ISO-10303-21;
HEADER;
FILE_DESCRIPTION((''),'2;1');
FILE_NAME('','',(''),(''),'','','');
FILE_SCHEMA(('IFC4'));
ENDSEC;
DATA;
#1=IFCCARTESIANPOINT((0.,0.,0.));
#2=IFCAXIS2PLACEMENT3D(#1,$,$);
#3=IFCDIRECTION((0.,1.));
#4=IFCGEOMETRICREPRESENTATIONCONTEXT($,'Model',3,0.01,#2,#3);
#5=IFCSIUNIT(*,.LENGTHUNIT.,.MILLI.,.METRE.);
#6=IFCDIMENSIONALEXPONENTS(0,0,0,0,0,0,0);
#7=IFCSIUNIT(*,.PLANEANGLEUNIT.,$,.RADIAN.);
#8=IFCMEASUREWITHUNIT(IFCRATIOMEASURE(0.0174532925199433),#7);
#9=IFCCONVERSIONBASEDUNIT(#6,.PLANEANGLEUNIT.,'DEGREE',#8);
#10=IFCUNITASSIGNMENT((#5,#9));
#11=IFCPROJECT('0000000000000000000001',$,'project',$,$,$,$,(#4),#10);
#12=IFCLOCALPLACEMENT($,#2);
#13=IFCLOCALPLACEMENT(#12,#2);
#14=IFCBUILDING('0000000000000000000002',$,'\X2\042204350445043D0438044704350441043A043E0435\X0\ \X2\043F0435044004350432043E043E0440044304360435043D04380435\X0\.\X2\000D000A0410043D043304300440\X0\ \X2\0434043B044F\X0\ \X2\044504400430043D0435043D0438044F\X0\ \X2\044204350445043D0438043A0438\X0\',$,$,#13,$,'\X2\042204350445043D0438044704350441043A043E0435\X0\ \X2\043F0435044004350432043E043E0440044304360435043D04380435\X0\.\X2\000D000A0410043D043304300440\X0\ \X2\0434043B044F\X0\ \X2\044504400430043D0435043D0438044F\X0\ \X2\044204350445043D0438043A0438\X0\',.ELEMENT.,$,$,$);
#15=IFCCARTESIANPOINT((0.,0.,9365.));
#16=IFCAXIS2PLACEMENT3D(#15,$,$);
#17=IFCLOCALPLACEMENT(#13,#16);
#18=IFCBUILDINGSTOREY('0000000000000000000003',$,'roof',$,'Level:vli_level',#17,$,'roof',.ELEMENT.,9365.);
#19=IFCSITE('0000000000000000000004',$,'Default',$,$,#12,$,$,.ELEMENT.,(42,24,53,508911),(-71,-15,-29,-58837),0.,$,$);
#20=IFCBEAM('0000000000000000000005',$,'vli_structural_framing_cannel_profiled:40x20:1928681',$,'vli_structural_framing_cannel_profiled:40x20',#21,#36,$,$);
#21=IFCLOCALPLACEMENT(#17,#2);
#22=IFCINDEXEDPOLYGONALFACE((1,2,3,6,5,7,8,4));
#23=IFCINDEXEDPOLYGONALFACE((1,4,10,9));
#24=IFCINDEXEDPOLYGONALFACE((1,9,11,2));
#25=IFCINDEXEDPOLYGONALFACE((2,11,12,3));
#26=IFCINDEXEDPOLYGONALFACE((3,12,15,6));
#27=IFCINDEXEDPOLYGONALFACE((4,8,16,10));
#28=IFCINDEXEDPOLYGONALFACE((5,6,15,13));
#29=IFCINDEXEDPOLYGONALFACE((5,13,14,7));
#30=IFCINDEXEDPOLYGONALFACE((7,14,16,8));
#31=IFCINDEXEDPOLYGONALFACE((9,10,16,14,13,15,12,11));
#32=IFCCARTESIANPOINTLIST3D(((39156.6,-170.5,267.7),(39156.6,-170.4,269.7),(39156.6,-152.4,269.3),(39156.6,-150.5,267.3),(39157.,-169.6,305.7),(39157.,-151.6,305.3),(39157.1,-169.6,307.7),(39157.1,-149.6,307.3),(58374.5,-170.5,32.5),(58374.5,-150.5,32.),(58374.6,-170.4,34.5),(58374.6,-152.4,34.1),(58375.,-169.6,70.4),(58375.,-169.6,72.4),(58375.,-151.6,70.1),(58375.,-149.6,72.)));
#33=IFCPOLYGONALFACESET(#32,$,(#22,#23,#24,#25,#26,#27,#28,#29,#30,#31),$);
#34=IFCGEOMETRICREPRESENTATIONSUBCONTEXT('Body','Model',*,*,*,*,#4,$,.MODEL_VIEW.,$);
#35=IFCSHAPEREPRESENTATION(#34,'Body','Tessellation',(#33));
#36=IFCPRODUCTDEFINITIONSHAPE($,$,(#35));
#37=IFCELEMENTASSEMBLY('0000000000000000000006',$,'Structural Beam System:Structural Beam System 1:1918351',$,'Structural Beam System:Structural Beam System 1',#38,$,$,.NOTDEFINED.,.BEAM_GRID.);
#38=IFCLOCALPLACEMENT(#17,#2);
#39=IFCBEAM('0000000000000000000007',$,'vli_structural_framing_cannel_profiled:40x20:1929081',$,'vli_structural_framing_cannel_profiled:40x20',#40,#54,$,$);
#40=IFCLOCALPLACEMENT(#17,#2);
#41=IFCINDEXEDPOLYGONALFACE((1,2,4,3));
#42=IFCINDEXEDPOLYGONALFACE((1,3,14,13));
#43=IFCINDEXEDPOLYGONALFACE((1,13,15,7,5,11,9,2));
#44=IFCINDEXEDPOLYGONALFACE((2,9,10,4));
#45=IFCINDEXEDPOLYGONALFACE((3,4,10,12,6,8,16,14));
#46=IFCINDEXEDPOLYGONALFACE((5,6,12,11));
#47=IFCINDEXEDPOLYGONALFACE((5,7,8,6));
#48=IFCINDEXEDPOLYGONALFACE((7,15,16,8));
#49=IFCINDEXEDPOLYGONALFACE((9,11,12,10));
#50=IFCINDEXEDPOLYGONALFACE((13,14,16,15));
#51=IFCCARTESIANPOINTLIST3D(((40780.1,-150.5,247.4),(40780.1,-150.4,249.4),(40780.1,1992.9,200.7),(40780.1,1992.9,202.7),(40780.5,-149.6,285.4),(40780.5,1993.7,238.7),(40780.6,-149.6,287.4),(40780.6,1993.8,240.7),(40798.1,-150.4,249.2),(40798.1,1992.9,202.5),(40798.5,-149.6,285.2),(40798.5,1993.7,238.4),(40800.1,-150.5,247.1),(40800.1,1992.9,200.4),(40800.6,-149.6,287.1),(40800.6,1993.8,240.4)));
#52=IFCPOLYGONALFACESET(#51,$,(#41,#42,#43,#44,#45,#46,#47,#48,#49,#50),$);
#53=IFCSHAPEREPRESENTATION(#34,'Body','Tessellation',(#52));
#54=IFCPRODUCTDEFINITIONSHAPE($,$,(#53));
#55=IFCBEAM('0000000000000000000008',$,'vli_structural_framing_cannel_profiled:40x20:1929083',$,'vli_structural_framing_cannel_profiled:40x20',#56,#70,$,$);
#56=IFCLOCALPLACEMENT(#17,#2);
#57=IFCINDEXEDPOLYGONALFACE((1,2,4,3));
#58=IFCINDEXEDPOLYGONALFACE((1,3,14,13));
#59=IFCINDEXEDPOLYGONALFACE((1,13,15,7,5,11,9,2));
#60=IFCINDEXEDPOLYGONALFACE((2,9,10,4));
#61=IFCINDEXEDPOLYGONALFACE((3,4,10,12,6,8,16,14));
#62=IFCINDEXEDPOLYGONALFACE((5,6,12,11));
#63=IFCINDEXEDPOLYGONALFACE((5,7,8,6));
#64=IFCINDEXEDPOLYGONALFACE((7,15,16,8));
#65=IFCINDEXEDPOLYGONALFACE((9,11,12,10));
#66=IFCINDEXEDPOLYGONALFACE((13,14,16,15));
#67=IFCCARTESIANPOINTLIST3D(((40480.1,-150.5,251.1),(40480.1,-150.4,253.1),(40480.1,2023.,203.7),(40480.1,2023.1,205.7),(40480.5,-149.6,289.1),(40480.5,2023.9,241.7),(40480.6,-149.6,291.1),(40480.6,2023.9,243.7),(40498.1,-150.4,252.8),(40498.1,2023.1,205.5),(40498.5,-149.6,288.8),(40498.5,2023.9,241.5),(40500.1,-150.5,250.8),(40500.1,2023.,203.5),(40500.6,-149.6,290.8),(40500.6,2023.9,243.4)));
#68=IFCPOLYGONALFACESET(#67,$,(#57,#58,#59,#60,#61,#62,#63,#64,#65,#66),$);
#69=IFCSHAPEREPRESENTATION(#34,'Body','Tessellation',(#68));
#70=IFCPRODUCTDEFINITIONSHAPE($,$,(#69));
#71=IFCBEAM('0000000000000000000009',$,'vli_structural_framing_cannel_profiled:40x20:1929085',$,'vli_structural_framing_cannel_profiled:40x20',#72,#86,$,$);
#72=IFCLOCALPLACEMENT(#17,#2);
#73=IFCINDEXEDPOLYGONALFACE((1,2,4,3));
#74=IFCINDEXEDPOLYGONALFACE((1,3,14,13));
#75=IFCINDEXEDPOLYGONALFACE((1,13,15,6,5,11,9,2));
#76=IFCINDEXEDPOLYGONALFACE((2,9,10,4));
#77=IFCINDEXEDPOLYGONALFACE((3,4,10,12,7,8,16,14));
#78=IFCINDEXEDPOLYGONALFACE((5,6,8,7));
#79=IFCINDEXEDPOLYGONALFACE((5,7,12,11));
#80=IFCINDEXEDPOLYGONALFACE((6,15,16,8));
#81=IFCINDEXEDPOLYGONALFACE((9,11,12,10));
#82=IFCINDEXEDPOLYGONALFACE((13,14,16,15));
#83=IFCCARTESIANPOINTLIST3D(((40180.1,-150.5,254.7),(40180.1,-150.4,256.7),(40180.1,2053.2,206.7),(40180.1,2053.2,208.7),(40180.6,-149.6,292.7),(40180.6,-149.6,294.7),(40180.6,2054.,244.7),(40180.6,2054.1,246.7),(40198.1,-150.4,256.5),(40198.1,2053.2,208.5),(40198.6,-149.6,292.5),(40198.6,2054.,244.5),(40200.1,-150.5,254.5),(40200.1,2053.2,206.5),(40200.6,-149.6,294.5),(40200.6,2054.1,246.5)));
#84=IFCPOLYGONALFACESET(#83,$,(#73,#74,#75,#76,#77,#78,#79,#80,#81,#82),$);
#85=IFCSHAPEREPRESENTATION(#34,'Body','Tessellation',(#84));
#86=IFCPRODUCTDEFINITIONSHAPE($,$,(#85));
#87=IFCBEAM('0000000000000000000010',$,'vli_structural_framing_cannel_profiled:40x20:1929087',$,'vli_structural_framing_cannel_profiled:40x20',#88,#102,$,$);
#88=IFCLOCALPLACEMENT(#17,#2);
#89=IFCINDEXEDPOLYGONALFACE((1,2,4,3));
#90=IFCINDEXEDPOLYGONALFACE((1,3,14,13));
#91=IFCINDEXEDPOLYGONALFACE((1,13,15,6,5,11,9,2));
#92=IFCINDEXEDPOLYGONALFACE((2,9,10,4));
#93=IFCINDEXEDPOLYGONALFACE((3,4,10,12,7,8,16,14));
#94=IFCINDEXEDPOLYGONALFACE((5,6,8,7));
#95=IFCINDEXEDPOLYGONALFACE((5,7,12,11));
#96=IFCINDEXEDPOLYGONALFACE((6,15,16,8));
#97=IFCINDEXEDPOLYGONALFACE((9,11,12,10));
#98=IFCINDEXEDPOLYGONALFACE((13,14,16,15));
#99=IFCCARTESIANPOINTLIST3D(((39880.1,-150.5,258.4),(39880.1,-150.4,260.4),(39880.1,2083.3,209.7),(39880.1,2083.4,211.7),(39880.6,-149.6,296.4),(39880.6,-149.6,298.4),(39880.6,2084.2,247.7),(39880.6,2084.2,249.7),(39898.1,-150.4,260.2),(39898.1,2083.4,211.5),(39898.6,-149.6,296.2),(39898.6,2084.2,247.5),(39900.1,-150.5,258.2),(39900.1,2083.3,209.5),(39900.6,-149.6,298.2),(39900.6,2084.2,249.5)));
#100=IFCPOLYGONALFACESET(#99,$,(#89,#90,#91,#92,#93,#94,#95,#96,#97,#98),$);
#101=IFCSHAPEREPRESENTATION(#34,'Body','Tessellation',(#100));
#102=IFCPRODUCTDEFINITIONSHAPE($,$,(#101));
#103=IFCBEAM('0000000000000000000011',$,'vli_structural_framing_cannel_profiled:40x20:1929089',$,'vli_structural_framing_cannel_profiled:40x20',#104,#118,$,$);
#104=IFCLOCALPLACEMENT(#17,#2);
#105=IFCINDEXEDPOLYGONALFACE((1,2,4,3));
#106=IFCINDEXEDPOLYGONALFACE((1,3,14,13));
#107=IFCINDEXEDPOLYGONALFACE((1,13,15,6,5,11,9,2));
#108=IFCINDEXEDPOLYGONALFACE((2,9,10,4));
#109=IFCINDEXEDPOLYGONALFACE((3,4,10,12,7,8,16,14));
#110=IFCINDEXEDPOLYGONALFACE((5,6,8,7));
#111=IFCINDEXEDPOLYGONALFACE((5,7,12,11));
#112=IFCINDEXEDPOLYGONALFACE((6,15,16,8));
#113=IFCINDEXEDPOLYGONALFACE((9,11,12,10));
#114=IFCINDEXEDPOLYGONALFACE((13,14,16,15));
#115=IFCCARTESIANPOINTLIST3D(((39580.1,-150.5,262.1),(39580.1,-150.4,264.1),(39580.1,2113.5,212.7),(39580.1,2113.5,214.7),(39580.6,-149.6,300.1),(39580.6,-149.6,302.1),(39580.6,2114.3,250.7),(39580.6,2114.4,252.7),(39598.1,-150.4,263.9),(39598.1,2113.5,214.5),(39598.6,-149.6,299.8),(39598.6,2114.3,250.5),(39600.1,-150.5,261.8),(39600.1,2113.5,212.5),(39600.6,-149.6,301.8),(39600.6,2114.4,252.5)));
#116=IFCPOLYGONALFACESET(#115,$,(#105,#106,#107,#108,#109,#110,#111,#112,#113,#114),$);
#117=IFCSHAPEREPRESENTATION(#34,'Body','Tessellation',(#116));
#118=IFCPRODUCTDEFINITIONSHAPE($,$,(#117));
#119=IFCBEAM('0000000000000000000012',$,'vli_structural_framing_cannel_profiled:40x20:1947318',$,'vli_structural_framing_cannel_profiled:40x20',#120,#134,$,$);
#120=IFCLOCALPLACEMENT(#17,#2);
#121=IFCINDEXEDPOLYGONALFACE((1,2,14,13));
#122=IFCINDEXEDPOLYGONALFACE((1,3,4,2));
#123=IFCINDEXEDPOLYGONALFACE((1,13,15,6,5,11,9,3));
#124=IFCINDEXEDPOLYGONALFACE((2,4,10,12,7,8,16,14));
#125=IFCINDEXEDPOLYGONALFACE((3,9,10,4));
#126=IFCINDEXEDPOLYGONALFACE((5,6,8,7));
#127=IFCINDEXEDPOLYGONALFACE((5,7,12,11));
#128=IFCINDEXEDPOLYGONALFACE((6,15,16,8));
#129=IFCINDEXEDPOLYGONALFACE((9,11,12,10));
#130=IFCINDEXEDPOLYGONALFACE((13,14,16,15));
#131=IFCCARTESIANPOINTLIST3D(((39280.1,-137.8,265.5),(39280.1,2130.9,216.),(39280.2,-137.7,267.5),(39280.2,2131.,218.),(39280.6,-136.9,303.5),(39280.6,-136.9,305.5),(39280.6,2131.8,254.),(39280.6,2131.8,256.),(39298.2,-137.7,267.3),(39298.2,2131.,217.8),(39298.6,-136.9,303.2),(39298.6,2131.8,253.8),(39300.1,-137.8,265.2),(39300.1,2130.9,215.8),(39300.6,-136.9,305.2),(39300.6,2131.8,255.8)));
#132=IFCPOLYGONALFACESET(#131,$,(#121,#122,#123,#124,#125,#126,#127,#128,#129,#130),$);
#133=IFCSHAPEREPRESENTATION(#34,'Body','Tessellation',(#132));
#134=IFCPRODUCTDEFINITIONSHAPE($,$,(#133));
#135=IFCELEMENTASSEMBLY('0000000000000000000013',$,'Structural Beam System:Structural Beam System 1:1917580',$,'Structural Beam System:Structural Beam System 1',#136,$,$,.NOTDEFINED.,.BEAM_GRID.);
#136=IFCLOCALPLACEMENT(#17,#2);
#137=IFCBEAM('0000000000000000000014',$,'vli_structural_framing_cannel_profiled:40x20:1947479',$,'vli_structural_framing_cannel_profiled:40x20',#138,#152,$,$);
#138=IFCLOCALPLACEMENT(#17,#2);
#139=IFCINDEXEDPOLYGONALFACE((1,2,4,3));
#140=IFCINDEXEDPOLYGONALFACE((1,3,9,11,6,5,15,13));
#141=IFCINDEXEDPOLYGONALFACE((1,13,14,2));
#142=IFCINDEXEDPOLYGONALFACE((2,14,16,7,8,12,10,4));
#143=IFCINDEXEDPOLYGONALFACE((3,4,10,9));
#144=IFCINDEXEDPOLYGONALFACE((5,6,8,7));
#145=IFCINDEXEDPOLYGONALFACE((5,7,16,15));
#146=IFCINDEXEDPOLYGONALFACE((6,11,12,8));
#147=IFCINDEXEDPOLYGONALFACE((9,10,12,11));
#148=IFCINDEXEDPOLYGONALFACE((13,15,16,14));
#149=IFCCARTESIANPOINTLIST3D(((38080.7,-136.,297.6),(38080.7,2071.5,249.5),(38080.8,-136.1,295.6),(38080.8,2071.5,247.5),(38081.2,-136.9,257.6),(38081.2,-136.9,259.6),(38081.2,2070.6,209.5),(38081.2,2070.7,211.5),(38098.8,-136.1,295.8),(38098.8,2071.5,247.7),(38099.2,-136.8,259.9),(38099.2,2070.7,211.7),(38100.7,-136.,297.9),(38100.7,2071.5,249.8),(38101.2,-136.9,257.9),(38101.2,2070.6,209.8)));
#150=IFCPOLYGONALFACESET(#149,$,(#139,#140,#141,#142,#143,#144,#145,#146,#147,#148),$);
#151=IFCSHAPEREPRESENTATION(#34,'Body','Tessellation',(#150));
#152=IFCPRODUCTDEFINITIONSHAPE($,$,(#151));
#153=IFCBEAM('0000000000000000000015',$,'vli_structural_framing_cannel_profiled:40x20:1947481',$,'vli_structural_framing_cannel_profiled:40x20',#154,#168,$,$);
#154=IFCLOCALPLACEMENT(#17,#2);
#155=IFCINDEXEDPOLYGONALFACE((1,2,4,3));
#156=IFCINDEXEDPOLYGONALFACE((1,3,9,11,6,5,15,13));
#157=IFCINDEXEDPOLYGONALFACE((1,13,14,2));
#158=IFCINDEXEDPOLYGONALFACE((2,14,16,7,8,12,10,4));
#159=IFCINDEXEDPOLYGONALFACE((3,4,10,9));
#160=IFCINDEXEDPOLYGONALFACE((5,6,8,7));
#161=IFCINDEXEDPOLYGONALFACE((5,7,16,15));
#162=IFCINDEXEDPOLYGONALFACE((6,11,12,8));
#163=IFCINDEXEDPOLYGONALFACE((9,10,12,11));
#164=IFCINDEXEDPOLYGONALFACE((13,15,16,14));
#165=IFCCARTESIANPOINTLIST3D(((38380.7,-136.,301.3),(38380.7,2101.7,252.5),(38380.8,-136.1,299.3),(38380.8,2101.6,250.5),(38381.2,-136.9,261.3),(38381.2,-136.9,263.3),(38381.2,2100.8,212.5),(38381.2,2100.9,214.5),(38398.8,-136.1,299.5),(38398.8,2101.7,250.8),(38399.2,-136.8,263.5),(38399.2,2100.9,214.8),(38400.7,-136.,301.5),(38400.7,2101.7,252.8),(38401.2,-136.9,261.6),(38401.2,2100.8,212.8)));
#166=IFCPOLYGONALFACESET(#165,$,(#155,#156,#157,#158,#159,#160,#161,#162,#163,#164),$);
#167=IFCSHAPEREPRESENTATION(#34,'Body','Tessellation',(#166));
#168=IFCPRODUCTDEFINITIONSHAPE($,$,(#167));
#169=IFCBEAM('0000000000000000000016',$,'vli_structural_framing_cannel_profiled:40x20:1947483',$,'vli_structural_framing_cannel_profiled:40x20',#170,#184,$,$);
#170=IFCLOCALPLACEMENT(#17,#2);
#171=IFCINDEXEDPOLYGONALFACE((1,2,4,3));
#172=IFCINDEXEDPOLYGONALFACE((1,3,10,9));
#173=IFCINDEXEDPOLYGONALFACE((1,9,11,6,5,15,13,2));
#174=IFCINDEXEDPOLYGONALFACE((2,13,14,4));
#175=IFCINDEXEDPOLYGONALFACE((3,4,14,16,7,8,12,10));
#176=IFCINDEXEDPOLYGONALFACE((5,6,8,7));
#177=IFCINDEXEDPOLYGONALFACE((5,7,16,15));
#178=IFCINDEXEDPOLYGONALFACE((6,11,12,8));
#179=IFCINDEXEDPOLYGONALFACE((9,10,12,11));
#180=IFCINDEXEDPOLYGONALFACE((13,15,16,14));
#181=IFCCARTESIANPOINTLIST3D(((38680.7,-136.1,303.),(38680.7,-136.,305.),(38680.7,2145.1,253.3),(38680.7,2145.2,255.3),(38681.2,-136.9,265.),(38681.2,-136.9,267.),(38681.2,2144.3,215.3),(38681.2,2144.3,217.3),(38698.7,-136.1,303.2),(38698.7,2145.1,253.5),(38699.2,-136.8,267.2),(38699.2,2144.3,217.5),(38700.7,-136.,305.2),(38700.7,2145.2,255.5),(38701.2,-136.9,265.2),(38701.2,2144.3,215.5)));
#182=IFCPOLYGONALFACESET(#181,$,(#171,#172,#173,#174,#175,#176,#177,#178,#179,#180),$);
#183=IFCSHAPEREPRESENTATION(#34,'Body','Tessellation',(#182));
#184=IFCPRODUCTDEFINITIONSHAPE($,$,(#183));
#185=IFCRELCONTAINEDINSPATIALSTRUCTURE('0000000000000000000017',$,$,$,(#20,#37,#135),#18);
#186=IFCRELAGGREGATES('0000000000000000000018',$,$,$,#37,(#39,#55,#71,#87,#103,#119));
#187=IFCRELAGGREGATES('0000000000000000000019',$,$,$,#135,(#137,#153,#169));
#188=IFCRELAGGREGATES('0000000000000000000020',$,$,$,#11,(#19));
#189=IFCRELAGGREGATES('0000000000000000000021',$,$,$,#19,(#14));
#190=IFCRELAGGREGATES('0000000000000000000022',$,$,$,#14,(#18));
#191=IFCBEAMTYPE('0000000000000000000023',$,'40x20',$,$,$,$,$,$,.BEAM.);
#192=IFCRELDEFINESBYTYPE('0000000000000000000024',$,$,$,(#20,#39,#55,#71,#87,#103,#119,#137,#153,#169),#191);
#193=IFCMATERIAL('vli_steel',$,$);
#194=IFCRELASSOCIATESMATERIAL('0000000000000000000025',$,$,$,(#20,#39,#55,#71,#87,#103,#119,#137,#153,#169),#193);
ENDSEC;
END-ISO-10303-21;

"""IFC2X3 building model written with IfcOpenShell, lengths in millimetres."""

from ifc_helpers import new_model, entity, si_unit, converted_unit, direction, frame, origin, place, context, subcontext, project, spatial, polyline, outline, extrude, material, type_object, element, aggregate, save


model = new_model("IFC2X3")

# Units and contexts
model_context = context("Model", 3, precision=0.01, world=origin(), true_north=direction((0.0, 1.0)))
body_context = subcontext(model_context, "Body", "Model", "MODEL_VIEW")
ifc_project = project(units=[si_unit("LENGTHUNIT", "METRE", prefix="MILLI"), converted_unit("PLANEANGLEUNIT", "DEGREE", entity("IfcRatioMeasure", 0.0174532925199433), si_unit("PLANEANGLEUNIT", "RADIAN"), dimensions=[0, 0, 0, 0, 0, 0, 0])], contexts=[model_context])

# Site, building, storey
site_placement = place(None, origin())
site = spatial("IfcSite", under=ifc_project, at=site_placement, Name="Default", CompositionType="ELEMENT", RefLatitude=(42, 24, 53, 508911), RefLongitude=(-71, -15, -29, -58837), RefElevation=0.0)
building_placement = place(site_placement, origin())
building = spatial("IfcBuilding", under=site, at=building_placement, Name="Техническое перевооружение.\r\nАнгар для хранения техники", LongName="Техническое перевооружение.\r\nАнгар для хранения техники", CompositionType="ELEMENT")
storey_placement = place(building_placement, frame((0.0, 0.0, 9365.0)))
storey = spatial("IfcBuildingStorey", under=building, at=storey_placement, Name="roof", ObjectType="Level:vli_level", LongName="roof", CompositionType="ELEMENT", Elevation=9365.0)

# Shared definitions
ifc_material = material(Name="vli_steel")
beam_type = type_object("IfcBeamType", Name="40x20", PredefinedType="BEAM")

# Beam
beam_1_placement = place(storey_placement, frame((39157.1, -150.2, 307.3), z_axis=(0.01224, 0.0, 0.999925), x_axis=(0.999925, 0.0, -0.01224)))
element("IfcBeam", 1, at=beam_1_placement, inside=storey, type_object=beam_type, material=ifc_material, Name="vli_structural_framing_cannel_profiled:40x20:1928681", ObjectType="vli_structural_framing_cannel_profiled:40x20", context=body_context, shape_type="SweptSolid", body=[
    extrude(outline(polyline([(-10.5, -20.0), (9.5, -20.0), (9.5, -18.0), (-8.5, -18.0), (-8.5, 18.0), (9.5, 18.0), (9.5, 20.0), (-10.5, 20.0), (-10.5, -20.0)])), frame((0.0, -10.3, -19.8), z_axis=(1.0, 0.0, 0.0), x_axis=(0.0, -0.999763, 0.021791)), (0.0, 0.0, 1.0), 19219.4),
])

# Element assemblies, beams
assembly_1_placement = place(storey_placement, origin())
assembly_1 = element("IfcElementAssembly", 2, at=assembly_1_placement, inside=storey, Name="Structural Beam System:Structural Beam System 1:1918351", ObjectType="Structural Beam System:Structural Beam System 1", AssemblyPlace="NOTDEFINED", PredefinedType="BEAM_GRID")
beam_2_placement = place(assembly_1_placement, frame((40800.0, 1994.4, 240.4), z_axis=(0.0, 0.02179, 0.999763), x_axis=(0.0, -0.999763, 0.02179)))
beam_2 = element("IfcBeam", 3, at=beam_2_placement, type_object=beam_type, material=ifc_material, Name="vli_structural_framing_cannel_profiled:40x20:1929081", ObjectType="vli_structural_framing_cannel_profiled:40x20", context=body_context, shape_type="SweptSolid", body=[
    extrude(outline(polyline([(-10.5, -20.0), (9.5, -20.0), (9.5, -18.0), (-8.5, -18.0), (-8.5, 18.0), (9.5, 18.0), (9.5, 20.0), (-10.5, 20.0), (-10.5, -20.0)])), frame((0.7, -10.1, -19.9), z_axis=(1.0, 0.0, 0.0), x_axis=(0.0, -0.999925, 0.012243)), (0.0, 0.0, 1.0), 2143.8),
])
beam_3_placement = place(assembly_1_placement, frame((40500.0, 2024.6, 243.4), z_axis=(0.0, 0.02179, 0.999763), x_axis=(0.0, -0.999763, 0.02179)))
beam_3 = element("IfcBeam", 4, at=beam_3_placement, type_object=beam_type, material=ifc_material, Name="vli_structural_framing_cannel_profiled:40x20:1929083", ObjectType="vli_structural_framing_cannel_profiled:40x20", context=body_context, shape_type="SweptSolid", body=[
    extrude(outline(polyline([(-10.5, -20.0), (9.5, -20.0), (9.5, -18.0), (-8.5, -18.0), (-8.5, 18.0), (9.5, 18.0), (9.5, 20.0), (-10.5, 20.0), (-10.5, -20.0)])), frame((0.7, -10.1, -19.9), z_axis=(1.0, 0.0, 0.0), x_axis=(0.0, -0.999925, 0.012243)), (0.0, 0.0, 1.0), 2174.0),
])
beam_4_placement = place(assembly_1_placement, frame((40200.0, 2054.7, 246.4), z_axis=(0.0, 0.02179, 0.999763), x_axis=(0.0, -0.999763, 0.02179)))
beam_4 = element("IfcBeam", 5, at=beam_4_placement, type_object=beam_type, material=ifc_material, Name="vli_structural_framing_cannel_profiled:40x20:1929085", ObjectType="vli_structural_framing_cannel_profiled:40x20", context=body_context, shape_type="SweptSolid", body=[
    extrude(outline(polyline([(-10.5, -20.0), (9.5, -20.0), (9.5, -18.0), (-8.5, -18.0), (-8.5, 18.0), (9.5, 18.0), (9.5, 20.0), (-10.5, 20.0), (-10.5, -20.0)])), frame((0.7, -10.1, -19.9), z_axis=(1.0, 0.0, 0.0), x_axis=(0.0, -0.999925, 0.012243)), (0.0, 0.0, 1.0), 2204.2),
])
beam_5_placement = place(assembly_1_placement, frame((39900.0, 2084.9, 249.5), z_axis=(0.0, 0.02179, 0.999763), x_axis=(0.0, -0.999763, 0.02179)))
beam_5 = element("IfcBeam", 6, at=beam_5_placement, type_object=beam_type, material=ifc_material, Name="vli_structural_framing_cannel_profiled:40x20:1929087", ObjectType="vli_structural_framing_cannel_profiled:40x20", context=body_context, shape_type="SweptSolid", body=[
    extrude(outline(polyline([(-10.5, -20.0), (9.5, -20.0), (9.5, -18.0), (-8.5, -18.0), (-8.5, 18.0), (9.5, 18.0), (9.5, 20.0), (-10.5, 20.0), (-10.5, -20.0)])), frame((0.7, -10.1, -19.9), z_axis=(1.0, 0.0, 0.0), x_axis=(0.0, -0.999925, 0.012243)), (0.0, 0.0, 1.0), 2234.3),
])
beam_6_placement = place(assembly_1_placement, frame((39600.0, 2115.0, 252.5), z_axis=(0.0, 0.02179, 0.999763), x_axis=(0.0, -0.999763, 0.02179)))
beam_6 = element("IfcBeam", 7, at=beam_6_placement, type_object=beam_type, material=ifc_material, Name="vli_structural_framing_cannel_profiled:40x20:1929089", ObjectType="vli_structural_framing_cannel_profiled:40x20", context=body_context, shape_type="SweptSolid", body=[
    extrude(outline(polyline([(-10.5, -20.0), (9.5, -20.0), (9.5, -18.0), (-8.5, -18.0), (-8.5, 18.0), (9.5, 18.0), (9.5, 20.0), (-10.5, 20.0), (-10.5, -20.0)])), frame((0.7, -10.1, -19.9), z_axis=(1.0, 0.0, 0.0), x_axis=(0.0, -0.999925, 0.012243)), (0.0, 0.0, 1.0), 2264.5),
])
beam_7_placement = place(assembly_1_placement, frame((39300.0, 2145.2, 255.5), z_axis=(0.0, 0.02179, 0.999763), x_axis=(0.0, -0.999763, 0.02179)))
beam_7 = element("IfcBeam", 8, at=beam_7_placement, type_object=beam_type, material=ifc_material, Name="vli_structural_framing_cannel_profiled:40x20:1947318", ObjectType="vli_structural_framing_cannel_profiled:40x20", context=body_context, shape_type="SweptSolid", body=[
    extrude(outline(polyline([(-10.5, -20.0), (9.5, -20.0), (9.5, -18.0), (-8.5, -18.0), (-8.5, 18.0), (9.5, 18.0), (9.5, 20.0), (-10.5, 20.0), (-10.5, -20.0)])), frame((13.4, -10.1, -19.9), z_axis=(1.0, 0.0, 0.0), x_axis=(0.0, -0.999925, 0.012243)), (0.0, 0.0, 1.0), 2269.2),
])
aggregate(assembly_1, [beam_2, beam_3, beam_4, beam_5, beam_6, beam_7])
assembly_2_placement = place(storey_placement, origin())
assembly_2 = element("IfcElementAssembly", 9, at=assembly_2_placement, inside=storey, Name="Structural Beam System:Structural Beam System 1:1917580", ObjectType="Structural Beam System:Structural Beam System 1", AssemblyPlace="NOTDEFINED", PredefinedType="BEAM_GRID")
beam_8_placement = place(assembly_2_placement, frame((38100.1, 2086.8, 249.4), z_axis=(0.0, 0.02179, 0.999763), x_axis=(0.0, -0.999763, 0.02179)))
beam_8 = element("IfcBeam", 10, at=beam_8_placement, type_object=beam_type, material=ifc_material, Name="vli_structural_framing_cannel_profiled:40x20:1947479", ObjectType="vli_structural_framing_cannel_profiled:40x20", context=body_context, shape_type="SweptSolid", body=[
    extrude(outline(polyline([(-10.5, -20.0), (9.5, -20.0), (9.5, -18.0), (-8.5, -18.0), (-8.5, 18.0), (9.5, 18.0), (9.5, 20.0), (-10.5, 20.0), (-10.5, -20.0)])), frame((15.3, -9.7, -20.1), z_axis=(1.0, 0.0, 0.0), x_axis=(0.0, -0.999925, -0.012243)), (0.0, 0.0, 1.0), 2208.1),
])
beam_9_placement = place(assembly_2_placement, frame((38400.1, 2116.9, 252.4), z_axis=(0.0, 0.02179, 0.999763), x_axis=(0.0, -0.999763, 0.02179)))
beam_9 = element("IfcBeam", 11, at=beam_9_placement, type_object=beam_type, material=ifc_material, Name="vli_structural_framing_cannel_profiled:40x20:1947481", ObjectType="vli_structural_framing_cannel_profiled:40x20", context=body_context, shape_type="SweptSolid", body=[
    extrude(outline(polyline([(-10.5, -20.0), (9.5, -20.0), (9.5, -18.0), (-8.5, -18.0), (-8.5, 18.0), (9.5, 18.0), (9.5, 20.0), (-10.5, 20.0), (-10.5, -20.0)])), frame((15.3, -9.7, -20.1), z_axis=(1.0, 0.0, 0.0), x_axis=(0.0, -0.999925, -0.012243)), (0.0, 0.0, 1.0), 2238.2),
])
beam_10_placement = place(assembly_2_placement, frame((38700.1, 2145.2, 255.5), z_axis=(0.0, 0.02179, 0.999763), x_axis=(0.0, -0.999763, 0.02179)))
beam_10 = element("IfcBeam", 12, at=beam_10_placement, type_object=beam_type, material=ifc_material, Name="vli_structural_framing_cannel_profiled:40x20:1947483", ObjectType="vli_structural_framing_cannel_profiled:40x20", context=body_context, shape_type="SweptSolid", body=[
    extrude(outline(polyline([(-10.5, -20.0), (9.5, -20.0), (9.5, -18.0), (-8.5, -18.0), (-8.5, 18.0), (9.5, 18.0), (9.5, 20.0), (-10.5, 20.0), (-10.5, -20.0)])), frame((0.0, -9.7, -20.1), z_axis=(1.0, 0.0, 0.0), x_axis=(0.0, -0.999925, -0.012243)), (0.0, 0.0, 1.0), 2281.7),
])
aggregate(assembly_2, [beam_8, beam_9, beam_10])

save(model, "model.ifc")
